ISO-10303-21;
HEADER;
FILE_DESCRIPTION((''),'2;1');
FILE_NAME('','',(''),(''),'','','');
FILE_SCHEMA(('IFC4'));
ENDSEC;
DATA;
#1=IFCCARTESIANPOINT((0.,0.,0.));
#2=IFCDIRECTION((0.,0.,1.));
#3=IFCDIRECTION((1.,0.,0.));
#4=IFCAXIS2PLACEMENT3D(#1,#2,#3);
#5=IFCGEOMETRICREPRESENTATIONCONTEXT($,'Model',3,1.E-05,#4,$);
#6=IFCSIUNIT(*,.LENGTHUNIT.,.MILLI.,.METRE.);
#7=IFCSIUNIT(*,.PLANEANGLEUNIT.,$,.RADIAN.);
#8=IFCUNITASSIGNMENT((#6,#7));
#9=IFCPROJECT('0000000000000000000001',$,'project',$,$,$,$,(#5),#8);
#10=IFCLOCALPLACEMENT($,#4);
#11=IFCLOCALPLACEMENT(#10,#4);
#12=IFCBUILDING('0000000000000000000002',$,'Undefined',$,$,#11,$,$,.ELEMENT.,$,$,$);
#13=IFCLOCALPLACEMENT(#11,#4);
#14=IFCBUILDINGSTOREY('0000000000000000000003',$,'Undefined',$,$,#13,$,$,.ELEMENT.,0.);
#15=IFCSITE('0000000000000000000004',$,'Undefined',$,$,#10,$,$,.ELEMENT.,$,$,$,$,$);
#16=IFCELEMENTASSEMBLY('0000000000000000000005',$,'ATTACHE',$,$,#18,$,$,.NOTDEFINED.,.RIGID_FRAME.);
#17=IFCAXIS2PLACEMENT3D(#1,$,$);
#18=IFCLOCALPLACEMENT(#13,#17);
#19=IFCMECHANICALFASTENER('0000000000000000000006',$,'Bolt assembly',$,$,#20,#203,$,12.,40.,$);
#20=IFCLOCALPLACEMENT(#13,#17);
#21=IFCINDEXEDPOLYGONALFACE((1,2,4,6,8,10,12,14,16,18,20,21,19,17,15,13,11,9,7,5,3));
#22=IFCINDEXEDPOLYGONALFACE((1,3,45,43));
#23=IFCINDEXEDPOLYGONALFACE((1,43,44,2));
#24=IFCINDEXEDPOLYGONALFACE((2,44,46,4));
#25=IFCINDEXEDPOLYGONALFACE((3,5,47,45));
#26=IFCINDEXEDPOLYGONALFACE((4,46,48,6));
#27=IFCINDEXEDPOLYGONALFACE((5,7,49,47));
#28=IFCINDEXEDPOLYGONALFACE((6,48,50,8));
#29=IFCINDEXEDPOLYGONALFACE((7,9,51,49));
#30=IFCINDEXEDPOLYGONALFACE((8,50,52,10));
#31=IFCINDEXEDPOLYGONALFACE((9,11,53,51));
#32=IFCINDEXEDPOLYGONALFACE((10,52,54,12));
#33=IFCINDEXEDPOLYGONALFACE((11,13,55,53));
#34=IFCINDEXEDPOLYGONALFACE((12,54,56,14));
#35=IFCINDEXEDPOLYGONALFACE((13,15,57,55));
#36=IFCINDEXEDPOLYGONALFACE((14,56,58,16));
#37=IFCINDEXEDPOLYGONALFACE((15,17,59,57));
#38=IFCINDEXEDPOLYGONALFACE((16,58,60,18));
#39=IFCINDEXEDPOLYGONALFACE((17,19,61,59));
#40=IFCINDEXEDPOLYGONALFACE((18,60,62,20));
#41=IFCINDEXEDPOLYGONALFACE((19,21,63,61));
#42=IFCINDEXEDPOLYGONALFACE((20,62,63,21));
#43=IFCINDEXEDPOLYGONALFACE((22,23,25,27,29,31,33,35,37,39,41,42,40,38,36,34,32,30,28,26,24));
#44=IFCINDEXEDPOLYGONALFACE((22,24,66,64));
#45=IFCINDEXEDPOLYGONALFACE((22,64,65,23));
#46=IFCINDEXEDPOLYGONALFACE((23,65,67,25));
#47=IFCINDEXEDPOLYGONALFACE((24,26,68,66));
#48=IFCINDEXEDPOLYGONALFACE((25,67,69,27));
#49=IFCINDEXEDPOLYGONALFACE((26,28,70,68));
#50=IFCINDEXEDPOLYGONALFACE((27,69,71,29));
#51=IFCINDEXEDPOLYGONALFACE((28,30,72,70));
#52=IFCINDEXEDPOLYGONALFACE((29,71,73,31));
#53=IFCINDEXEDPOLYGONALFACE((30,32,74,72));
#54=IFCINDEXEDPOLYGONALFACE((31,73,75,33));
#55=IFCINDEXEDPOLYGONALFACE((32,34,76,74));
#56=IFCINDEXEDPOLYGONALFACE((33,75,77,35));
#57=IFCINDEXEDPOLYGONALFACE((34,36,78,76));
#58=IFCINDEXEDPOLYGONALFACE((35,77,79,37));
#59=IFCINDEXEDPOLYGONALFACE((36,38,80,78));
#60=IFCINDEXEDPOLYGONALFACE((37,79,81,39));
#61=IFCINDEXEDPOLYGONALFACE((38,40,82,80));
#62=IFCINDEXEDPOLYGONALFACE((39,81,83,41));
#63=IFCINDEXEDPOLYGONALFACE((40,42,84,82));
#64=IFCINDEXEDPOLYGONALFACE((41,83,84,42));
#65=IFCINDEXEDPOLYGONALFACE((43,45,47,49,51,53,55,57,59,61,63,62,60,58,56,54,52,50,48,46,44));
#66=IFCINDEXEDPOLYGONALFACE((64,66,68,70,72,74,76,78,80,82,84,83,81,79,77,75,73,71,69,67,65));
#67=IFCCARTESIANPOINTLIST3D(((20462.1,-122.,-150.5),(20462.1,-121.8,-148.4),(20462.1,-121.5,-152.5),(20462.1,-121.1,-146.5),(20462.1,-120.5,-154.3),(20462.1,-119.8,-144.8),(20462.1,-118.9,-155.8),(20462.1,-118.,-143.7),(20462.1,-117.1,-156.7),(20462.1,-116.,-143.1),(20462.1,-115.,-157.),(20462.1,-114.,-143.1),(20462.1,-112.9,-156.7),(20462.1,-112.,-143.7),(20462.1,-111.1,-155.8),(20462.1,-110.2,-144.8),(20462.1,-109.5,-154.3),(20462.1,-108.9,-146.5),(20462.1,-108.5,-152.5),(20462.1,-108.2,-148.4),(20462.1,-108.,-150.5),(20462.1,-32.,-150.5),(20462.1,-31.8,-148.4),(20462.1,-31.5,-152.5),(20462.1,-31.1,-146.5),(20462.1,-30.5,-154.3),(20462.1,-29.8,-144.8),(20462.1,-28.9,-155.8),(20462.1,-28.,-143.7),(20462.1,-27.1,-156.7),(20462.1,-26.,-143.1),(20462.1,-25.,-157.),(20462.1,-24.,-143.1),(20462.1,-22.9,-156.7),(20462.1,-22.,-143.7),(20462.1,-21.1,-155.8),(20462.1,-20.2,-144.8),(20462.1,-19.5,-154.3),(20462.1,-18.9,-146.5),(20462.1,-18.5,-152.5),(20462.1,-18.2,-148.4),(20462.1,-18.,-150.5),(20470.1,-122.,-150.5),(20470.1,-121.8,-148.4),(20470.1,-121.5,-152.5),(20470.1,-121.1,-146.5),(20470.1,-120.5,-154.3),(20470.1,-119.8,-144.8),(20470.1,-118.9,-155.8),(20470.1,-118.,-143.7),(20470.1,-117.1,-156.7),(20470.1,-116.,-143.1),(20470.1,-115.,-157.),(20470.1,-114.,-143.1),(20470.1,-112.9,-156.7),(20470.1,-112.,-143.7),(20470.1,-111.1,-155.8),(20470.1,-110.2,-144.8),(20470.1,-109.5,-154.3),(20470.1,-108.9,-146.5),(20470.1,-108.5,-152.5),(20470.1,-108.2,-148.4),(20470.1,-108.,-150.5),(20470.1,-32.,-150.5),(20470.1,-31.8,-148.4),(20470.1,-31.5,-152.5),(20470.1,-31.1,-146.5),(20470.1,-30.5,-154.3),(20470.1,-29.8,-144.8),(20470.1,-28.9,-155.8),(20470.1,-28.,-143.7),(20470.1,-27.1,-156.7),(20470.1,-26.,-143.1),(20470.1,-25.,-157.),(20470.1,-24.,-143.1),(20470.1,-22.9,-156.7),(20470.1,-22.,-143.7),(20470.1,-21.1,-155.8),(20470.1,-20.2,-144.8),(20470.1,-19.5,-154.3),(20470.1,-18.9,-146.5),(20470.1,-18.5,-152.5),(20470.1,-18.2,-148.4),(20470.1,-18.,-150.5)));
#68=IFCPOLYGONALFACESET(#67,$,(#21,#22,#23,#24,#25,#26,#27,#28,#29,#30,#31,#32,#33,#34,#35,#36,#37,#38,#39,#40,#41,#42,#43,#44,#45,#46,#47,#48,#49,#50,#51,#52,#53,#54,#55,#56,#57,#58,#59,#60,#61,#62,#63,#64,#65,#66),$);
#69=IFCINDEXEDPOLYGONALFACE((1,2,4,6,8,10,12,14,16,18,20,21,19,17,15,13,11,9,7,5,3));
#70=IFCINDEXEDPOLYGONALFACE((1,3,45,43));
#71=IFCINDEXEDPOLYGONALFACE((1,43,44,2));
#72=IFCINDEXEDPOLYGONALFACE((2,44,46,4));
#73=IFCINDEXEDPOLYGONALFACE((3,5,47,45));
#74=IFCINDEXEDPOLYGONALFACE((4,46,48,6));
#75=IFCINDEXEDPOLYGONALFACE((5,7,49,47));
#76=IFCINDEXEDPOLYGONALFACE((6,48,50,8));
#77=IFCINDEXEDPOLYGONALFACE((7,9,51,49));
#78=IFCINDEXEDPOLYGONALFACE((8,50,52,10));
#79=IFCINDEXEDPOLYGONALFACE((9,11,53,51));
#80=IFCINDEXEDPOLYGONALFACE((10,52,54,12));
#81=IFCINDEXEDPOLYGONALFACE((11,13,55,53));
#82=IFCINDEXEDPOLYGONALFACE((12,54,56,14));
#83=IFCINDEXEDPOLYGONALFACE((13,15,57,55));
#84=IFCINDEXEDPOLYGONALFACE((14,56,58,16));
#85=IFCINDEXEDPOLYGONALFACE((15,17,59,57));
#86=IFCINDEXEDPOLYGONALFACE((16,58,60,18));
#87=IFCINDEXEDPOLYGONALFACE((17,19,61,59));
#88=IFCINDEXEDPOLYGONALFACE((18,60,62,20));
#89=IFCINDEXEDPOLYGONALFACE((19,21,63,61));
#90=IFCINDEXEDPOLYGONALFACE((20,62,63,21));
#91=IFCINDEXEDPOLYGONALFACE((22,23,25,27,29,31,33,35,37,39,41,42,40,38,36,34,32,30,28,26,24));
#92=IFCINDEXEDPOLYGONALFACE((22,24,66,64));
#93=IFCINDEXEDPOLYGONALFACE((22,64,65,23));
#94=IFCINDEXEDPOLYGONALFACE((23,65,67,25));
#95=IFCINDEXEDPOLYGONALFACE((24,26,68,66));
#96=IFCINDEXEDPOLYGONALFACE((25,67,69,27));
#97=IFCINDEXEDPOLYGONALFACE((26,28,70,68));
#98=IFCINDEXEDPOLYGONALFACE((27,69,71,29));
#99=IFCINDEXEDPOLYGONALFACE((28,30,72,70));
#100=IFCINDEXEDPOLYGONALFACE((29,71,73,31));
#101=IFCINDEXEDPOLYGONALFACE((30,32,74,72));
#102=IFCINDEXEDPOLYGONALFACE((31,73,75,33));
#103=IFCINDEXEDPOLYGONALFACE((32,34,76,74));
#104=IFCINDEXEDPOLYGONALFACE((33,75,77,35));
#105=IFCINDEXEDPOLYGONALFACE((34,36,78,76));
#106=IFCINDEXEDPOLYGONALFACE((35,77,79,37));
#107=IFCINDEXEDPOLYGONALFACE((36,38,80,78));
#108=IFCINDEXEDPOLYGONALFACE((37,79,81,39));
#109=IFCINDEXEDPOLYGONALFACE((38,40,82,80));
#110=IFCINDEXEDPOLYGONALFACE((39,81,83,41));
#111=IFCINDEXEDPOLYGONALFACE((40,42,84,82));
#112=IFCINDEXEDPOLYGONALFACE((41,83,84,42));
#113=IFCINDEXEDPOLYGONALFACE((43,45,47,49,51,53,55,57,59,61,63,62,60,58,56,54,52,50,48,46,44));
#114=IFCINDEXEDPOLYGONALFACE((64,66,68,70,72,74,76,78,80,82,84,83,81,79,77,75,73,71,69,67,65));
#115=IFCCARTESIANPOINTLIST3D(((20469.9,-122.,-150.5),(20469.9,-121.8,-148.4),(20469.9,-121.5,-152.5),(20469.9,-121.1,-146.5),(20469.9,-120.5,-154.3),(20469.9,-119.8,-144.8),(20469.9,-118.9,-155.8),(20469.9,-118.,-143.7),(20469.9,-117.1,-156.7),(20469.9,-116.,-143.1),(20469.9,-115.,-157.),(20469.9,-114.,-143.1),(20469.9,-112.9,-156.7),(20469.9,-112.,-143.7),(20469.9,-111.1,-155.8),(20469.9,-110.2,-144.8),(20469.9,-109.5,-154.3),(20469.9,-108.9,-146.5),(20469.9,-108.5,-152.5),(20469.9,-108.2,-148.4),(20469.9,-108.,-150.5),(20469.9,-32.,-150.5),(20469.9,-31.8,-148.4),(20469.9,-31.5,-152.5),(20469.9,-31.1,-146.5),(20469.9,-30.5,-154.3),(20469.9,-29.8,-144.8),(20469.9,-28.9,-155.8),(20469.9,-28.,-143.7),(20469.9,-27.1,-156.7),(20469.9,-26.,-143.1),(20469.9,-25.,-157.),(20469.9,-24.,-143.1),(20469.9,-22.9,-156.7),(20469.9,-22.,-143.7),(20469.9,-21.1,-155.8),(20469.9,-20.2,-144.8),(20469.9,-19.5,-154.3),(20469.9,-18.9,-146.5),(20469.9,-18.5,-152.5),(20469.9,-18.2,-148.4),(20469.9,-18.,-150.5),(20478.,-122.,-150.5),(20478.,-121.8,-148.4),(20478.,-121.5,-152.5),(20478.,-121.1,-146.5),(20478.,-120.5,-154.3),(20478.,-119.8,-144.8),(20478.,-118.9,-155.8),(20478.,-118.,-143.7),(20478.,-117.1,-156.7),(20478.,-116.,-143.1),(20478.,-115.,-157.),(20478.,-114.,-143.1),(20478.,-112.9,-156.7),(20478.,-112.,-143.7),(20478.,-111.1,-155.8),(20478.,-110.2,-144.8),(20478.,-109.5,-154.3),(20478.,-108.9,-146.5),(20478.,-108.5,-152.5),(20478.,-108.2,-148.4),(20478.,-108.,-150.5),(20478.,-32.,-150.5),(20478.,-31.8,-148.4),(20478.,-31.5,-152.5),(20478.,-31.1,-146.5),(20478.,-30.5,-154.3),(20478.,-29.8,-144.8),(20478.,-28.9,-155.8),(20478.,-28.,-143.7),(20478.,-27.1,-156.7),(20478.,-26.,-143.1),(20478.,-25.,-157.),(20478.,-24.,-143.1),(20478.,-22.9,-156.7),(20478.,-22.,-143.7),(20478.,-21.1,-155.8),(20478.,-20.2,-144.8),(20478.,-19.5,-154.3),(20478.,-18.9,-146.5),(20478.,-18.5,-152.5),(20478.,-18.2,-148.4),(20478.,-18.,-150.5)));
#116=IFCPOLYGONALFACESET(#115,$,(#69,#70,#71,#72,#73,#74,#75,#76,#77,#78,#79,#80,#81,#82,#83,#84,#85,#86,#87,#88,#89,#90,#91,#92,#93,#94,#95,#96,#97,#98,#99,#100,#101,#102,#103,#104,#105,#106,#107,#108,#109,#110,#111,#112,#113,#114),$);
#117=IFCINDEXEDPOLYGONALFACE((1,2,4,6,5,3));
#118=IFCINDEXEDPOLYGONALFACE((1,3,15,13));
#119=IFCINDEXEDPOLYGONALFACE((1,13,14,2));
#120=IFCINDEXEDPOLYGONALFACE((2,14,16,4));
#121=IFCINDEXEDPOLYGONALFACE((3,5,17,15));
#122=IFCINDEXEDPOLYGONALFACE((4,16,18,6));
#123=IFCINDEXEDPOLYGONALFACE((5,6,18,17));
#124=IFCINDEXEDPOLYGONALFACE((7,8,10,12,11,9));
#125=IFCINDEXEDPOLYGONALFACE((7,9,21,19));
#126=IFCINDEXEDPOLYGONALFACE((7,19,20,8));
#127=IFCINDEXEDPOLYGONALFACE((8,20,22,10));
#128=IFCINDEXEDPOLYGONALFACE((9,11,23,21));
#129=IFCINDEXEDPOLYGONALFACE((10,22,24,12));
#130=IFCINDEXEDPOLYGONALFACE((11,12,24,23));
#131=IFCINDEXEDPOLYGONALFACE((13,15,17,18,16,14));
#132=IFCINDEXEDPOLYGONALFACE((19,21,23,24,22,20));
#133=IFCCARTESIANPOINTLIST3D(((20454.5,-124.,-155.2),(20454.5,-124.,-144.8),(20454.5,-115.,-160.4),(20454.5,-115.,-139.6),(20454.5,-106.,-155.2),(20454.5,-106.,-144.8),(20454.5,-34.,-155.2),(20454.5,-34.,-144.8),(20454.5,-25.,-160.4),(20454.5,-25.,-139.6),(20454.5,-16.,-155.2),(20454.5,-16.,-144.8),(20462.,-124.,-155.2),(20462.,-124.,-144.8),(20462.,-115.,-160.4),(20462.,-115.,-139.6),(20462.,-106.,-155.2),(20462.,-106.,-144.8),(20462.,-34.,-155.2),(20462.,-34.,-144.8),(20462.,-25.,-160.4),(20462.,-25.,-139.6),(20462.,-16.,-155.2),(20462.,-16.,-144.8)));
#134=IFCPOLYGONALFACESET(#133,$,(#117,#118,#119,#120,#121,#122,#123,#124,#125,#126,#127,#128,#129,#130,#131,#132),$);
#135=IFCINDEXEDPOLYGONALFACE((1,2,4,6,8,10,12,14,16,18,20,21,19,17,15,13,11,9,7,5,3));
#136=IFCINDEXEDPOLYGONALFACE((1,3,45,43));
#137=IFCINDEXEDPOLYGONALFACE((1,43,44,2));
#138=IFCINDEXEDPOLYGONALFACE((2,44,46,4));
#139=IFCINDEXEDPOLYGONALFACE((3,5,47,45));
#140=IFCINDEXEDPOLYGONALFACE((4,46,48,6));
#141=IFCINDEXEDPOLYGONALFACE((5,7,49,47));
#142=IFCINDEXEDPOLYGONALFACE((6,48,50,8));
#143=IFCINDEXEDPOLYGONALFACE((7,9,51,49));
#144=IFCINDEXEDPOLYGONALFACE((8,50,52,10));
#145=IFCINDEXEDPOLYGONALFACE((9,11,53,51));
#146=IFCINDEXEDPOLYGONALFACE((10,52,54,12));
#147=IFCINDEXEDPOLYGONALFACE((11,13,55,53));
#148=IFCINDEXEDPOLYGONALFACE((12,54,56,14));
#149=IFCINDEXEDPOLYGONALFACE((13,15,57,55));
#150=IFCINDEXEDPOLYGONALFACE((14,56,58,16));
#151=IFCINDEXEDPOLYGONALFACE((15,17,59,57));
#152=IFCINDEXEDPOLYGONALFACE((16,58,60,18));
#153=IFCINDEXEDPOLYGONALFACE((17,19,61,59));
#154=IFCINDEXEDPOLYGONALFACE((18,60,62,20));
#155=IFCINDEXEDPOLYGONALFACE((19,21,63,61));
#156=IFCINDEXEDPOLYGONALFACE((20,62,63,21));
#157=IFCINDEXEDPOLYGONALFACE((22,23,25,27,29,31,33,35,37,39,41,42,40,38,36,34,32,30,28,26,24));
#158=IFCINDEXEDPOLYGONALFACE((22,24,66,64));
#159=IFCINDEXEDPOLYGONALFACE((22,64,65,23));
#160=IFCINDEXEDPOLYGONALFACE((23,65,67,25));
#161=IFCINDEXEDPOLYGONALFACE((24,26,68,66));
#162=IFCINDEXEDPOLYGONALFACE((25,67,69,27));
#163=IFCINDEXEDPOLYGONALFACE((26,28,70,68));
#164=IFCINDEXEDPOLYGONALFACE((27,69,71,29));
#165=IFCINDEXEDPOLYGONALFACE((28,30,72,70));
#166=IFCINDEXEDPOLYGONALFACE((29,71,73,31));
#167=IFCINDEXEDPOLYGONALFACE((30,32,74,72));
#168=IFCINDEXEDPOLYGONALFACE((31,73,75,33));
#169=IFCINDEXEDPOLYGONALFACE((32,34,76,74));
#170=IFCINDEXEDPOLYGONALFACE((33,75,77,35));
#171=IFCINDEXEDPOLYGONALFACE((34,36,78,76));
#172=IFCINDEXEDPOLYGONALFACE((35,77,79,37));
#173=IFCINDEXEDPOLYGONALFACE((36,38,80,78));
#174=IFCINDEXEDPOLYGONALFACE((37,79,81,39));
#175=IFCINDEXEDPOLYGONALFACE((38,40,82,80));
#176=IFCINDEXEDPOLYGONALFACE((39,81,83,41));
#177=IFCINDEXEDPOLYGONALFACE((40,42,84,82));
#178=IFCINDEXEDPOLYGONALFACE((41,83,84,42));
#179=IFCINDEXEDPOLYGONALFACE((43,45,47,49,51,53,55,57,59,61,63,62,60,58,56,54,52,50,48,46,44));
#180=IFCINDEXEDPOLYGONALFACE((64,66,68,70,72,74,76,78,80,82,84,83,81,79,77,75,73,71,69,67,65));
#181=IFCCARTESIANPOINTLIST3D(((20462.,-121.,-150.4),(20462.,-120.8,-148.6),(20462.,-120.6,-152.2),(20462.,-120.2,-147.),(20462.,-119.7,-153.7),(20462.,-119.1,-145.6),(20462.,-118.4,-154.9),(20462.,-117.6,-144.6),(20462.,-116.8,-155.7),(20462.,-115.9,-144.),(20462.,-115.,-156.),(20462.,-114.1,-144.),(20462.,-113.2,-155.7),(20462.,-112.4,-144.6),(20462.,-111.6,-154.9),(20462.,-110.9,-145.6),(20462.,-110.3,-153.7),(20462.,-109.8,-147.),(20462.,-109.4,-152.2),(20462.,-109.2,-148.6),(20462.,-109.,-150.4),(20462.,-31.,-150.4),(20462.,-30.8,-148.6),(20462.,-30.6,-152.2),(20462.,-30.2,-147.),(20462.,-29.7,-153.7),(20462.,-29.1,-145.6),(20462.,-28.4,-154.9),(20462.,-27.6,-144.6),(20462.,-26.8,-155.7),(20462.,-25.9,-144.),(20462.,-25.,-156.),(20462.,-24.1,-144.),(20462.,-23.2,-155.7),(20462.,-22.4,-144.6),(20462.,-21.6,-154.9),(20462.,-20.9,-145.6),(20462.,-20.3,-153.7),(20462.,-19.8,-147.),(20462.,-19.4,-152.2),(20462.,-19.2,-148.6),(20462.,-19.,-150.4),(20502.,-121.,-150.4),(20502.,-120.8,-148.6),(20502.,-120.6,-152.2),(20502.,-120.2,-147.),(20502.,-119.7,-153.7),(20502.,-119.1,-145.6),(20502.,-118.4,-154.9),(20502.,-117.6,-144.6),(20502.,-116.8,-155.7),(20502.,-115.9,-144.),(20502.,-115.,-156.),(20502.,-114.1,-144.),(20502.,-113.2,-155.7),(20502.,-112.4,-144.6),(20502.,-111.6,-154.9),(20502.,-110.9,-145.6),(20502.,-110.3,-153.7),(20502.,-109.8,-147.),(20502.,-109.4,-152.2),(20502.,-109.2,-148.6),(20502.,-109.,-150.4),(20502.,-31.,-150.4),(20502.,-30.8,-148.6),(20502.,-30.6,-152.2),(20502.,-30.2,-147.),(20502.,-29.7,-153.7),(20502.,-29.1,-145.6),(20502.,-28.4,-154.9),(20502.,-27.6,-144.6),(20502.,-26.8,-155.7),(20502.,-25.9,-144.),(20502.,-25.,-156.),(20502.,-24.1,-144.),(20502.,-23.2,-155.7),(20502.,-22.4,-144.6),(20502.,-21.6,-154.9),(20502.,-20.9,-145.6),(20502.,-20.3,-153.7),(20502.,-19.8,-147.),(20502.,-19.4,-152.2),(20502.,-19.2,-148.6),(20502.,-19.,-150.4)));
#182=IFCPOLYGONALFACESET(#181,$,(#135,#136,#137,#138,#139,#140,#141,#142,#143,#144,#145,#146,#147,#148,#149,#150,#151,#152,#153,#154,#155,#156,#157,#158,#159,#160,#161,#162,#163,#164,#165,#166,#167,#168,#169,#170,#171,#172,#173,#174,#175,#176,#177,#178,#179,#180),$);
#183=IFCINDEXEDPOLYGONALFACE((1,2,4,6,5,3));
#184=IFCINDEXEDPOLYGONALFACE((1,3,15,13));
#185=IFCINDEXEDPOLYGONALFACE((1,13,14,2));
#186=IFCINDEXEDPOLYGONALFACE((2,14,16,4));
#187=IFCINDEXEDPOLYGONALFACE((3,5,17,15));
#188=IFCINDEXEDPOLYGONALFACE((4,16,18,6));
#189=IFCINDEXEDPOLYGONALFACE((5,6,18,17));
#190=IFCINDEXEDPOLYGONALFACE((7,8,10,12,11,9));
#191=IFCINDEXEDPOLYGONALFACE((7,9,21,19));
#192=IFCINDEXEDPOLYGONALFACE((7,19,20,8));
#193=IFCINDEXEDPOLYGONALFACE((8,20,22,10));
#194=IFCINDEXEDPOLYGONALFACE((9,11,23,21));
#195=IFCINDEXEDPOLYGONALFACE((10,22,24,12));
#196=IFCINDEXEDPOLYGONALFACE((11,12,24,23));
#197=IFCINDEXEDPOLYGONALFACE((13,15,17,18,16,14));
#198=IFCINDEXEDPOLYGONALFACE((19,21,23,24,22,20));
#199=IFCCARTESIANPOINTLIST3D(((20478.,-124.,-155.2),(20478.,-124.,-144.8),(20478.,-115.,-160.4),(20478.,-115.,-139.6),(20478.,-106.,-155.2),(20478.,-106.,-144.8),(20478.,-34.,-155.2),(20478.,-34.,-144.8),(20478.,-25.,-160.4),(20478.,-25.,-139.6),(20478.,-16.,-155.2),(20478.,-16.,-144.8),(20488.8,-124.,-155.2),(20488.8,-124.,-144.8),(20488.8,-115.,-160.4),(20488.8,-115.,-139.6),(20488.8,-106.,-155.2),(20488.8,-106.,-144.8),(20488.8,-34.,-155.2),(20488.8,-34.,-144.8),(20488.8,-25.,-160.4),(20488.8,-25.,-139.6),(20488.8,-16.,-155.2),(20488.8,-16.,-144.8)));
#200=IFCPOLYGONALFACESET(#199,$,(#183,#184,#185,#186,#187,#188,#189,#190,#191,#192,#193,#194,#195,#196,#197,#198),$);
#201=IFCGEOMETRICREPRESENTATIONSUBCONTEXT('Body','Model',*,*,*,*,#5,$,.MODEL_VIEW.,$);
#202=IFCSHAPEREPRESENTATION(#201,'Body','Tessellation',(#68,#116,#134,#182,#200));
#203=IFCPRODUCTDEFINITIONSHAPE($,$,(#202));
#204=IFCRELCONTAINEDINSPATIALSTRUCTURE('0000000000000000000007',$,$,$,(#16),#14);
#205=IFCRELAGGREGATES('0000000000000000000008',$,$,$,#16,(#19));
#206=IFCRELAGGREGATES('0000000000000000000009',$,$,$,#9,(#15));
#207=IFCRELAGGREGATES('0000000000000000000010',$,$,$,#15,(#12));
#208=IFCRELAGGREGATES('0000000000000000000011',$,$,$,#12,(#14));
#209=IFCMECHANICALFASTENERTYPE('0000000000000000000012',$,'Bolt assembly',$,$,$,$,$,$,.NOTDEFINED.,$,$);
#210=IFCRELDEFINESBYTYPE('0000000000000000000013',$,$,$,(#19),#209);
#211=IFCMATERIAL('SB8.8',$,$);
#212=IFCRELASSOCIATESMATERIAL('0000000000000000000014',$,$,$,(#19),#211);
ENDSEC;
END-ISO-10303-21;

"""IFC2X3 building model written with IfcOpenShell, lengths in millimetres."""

from ifc_helpers import new_model, si_unit, frame, origin_with_axes, origin_2d_with_axis, place, context, subcontext, project, spatial, polyline, circle, outline, extrude, source, transform, mapped, material, type_object, element, aggregate, save


model = new_model("IFC2X3")

# Units and contexts
model_context = context("Model", 3, precision=1e-05, world=origin_with_axes())
body_context = subcontext(model_context, "Body", "Model", "MODEL_VIEW")
ifc_project = project(units=[si_unit("LENGTHUNIT", "METRE", prefix="MILLI"), si_unit("PLANEANGLEUNIT", "RADIAN")], contexts=[model_context])

# Site, building, storey
site_placement = place(None, origin_with_axes())
site = spatial("IfcSite", under=ifc_project, at=site_placement, Name="Undefined", CompositionType="ELEMENT")
building_placement = place(site_placement, origin_with_axes())
building = spatial("IfcBuilding", under=site, at=building_placement, Name="Undefined", CompositionType="ELEMENT")
storey_placement = place(building_placement, origin_with_axes())
storey = spatial("IfcBuildingStorey", under=building, at=storey_placement, Name="Undefined", CompositionType="ELEMENT", Elevation=0.0)

# Element assembly
assembly_1_placement = place(storey_placement, origin_with_axes())
assembly_1 = element("IfcElementAssembly", 1, at=assembly_1_placement, inside=storey, Name="ATTACHE", AssemblyPlace="NOTDEFINED", PredefinedType="RIGID_FRAME")

# Mechanical fastener
ifc_material_1 = material(Name="SB8.8")
mechanical_fastener_type = type_object("IfcMechanicalFastenerType", Name="Bolt assembly")
shared_shape_1 = source(origin_with_axes(), body_context, "Body", "SweptSolid", [
    extrude(circle(Radius=7.0, at=origin_2d_with_axis()), frame((0.0, -10.4, 0.0), z_axis=(0.0, 1.0, 0.0), x_axis=(1.0, 0.0, 0.0)), (0.0, 0.0, 1.0), 8.0),
    extrude(circle(Radius=7.0, at=origin_2d_with_axis()), frame((0.0, -2.6, 0.0), z_axis=(0.0, 1.0, 0.0), x_axis=(1.0, 0.0, 0.0)), (0.0, 0.0, 1.0), 8.1),
    extrude(outline(polyline([(10.4, 0.0), (5.2, 9.0), (-5.2, 9.0), (-10.4, 0.0), (-5.2, -9.0), (5.2, -9.0), (10.4, 0.0)])), frame((0.0, -18.0, 0.0), z_axis=(0.0, 1.0, 0.0), x_axis=(1.0, 0.0, 0.0)), (0.0, 0.0, 1.0), 7.5),
    extrude(circle(Radius=6.0, at=origin_2d_with_axis()), frame((0.0, -10.5, 0.0), z_axis=(0.0, 1.0, 0.0), x_axis=(1.0, 0.0, 0.0)), (0.0, 0.0, 1.0), 40.0),
    extrude(outline(polyline([(10.4, 0.0), (5.2, 9.0), (-5.2, 9.0), (-10.4, 0.0), (-5.2, -9.0), (5.2, -9.0), (10.4, 0.0)])), frame((0.0, 5.5, 0.0), z_axis=(0.0, 1.0, 0.0), x_axis=(1.0, 0.0, 0.0)), (0.0, 0.0, 1.0), 10.8),
])
mechanical_fastener_1_placement = place(assembly_1_placement, frame((20472.5, -70.0, -150.0), z_axis=(0.0, -1.0, 0.0), x_axis=(0.0, 0.0, -1.0)))
mechanical_fastener_1 = element("IfcMechanicalFastener", 2, at=mechanical_fastener_1_placement, type_object=mechanical_fastener_type, material=ifc_material_1, Name="Bolt assembly", NominalDiameter=12.0, NominalLength=40.0, context=body_context, shape_type="MappedRepresentation", body=[
    mapped(shared_shape_1, transform((0.0, 0.0, -45.0))),
    mapped(shared_shape_1, transform((0.0, 0.0, 45.0))),
])
aggregate(assembly_1, [mechanical_fastener_1])

save(model, "model.ifc")
